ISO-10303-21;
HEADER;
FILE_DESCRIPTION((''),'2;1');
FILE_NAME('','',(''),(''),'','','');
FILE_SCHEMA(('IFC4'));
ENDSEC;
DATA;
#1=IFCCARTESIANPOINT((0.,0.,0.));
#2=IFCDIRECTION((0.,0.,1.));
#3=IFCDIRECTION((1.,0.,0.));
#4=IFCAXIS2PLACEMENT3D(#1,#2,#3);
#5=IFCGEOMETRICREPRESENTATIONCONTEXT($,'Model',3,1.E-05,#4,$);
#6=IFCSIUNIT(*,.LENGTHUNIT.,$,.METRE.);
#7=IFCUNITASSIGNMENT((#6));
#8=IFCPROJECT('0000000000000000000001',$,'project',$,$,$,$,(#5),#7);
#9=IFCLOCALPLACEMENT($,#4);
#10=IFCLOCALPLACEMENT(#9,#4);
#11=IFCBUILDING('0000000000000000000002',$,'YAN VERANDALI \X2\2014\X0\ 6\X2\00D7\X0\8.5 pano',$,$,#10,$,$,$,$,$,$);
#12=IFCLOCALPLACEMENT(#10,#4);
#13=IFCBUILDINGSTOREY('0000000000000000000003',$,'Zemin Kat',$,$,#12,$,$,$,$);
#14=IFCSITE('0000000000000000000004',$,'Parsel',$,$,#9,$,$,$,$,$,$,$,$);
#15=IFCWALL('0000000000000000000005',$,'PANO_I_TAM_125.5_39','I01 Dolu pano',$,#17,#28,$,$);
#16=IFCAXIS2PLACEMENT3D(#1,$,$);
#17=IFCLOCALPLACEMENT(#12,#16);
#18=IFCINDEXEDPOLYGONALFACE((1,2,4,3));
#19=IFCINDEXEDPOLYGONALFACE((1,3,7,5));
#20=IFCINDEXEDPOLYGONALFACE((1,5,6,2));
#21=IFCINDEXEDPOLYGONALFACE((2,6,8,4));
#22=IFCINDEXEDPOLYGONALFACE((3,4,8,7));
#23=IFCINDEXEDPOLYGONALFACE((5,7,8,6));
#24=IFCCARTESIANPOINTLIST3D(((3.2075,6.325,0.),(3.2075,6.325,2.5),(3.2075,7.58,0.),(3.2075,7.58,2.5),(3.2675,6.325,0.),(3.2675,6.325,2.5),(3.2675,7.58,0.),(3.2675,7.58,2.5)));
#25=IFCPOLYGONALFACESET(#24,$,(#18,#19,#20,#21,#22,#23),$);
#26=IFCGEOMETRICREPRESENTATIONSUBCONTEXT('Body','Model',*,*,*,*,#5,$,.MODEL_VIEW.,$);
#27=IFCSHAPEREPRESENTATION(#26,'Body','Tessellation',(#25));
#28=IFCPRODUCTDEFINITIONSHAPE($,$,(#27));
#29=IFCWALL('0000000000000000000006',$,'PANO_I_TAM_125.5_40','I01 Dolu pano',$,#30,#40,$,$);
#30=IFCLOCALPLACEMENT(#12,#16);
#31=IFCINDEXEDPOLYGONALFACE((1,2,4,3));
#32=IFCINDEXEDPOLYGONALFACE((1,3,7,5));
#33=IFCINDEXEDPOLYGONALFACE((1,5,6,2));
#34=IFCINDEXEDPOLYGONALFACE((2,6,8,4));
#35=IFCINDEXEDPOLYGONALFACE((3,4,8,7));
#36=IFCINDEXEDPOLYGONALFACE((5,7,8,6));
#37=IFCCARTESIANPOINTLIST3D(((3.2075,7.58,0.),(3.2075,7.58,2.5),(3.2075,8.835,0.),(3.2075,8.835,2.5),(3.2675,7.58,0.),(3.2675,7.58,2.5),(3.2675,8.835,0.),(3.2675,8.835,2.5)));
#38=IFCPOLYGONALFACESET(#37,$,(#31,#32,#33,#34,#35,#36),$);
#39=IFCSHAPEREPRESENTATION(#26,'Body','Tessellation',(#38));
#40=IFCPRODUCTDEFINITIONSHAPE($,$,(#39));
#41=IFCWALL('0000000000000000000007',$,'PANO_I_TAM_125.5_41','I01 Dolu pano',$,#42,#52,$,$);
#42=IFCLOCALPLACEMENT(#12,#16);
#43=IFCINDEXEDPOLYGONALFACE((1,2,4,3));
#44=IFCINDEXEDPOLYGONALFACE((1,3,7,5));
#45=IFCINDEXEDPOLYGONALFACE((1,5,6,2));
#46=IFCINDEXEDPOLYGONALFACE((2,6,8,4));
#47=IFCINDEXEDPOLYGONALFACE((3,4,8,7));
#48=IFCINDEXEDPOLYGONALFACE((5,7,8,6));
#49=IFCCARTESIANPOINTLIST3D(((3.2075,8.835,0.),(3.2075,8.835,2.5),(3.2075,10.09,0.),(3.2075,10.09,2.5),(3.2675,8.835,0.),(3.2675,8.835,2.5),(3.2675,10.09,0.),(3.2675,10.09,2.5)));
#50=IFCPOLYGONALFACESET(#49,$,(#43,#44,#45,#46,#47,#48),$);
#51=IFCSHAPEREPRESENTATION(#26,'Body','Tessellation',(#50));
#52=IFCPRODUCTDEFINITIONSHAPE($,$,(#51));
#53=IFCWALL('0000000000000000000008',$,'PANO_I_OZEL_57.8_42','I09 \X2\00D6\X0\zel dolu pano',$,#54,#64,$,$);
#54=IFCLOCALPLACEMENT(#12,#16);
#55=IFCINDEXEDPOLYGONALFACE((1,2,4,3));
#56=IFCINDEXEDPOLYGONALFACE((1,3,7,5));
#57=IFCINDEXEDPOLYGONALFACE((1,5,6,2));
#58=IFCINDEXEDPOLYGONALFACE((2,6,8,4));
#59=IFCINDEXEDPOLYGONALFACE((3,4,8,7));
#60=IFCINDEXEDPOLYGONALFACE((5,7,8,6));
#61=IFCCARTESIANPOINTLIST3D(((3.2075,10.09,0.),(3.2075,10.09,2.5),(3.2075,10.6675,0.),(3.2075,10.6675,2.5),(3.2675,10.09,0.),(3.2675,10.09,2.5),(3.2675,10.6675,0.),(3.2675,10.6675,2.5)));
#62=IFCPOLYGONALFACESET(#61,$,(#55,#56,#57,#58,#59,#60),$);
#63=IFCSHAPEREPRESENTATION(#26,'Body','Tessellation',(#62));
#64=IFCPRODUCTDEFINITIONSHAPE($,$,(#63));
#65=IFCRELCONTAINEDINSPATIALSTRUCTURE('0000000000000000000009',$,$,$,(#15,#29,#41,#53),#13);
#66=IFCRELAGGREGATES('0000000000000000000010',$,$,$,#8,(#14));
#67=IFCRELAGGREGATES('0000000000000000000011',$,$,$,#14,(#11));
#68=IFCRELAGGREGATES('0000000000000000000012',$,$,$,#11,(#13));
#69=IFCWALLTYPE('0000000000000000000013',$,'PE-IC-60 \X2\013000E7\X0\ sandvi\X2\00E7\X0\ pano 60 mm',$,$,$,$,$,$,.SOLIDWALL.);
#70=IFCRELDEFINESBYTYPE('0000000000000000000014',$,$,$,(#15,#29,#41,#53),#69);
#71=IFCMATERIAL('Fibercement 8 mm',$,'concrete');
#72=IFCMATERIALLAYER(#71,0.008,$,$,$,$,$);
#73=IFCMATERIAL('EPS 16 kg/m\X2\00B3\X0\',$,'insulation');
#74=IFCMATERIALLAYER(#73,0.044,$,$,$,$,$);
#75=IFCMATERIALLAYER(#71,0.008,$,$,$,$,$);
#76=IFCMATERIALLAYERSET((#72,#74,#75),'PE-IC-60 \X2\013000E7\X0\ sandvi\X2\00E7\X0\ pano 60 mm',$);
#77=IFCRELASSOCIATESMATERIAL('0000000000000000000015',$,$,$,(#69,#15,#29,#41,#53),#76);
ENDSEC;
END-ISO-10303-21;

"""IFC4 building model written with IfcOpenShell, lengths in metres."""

from ifc_helpers import new_model, si_unit, frame, origin_with_axes, place, context, subcontext, project, spatial, line, indexed_curve, outline, extrude, material, layer, layer_set, layer_usage, type_object, element, save


model = new_model("IFC4")

# Units and contexts
model_context = context("Model", 3, precision=1e-05, world=origin_with_axes())
body_context = subcontext(model_context, "Body", "Model", "MODEL_VIEW")
ifc_project = project(units=[si_unit("LENGTHUNIT", "METRE")], contexts=[model_context])

# Site, building, storey
site_placement = place(None, origin_with_axes())
site = spatial("IfcSite", under=ifc_project, at=site_placement, Name="Parsel")
building_placement = place(site_placement, origin_with_axes())
building = spatial("IfcBuilding", under=site, at=building_placement, Name="YAN VERANDALI — 6×8.5 pano")
storey_placement = place(building_placement, origin_with_axes())
storey = spatial("IfcBuildingStorey", under=building, at=storey_placement, Name="Zemin Kat")

# Shared definitions
ifc_material_1 = material(Name="Fibercement 8 mm", Category="concrete")
ifc_material_2 = material(Name="EPS 16 kg/m³", Category="insulation")

# Shared definitions
ifc_layer_1 = layer(ifc_material_1, 0.008)
ifc_layer_2 = layer(ifc_material_2, 0.044)
ifc_layer_3 = layer(ifc_material_1, 0.008)
ifc_layer_set_1 = layer_set([ifc_layer_1, ifc_layer_2, ifc_layer_3], Name="PE-IC-60 İç sandviç pano 60 mm")
wall_type_1 = type_object("IfcWallType", Name="PE-IC-60 İç sandviç pano 60 mm", PredefinedType="SOLIDWALL", material=ifc_layer_set_1)

# Walls
ifc_layer_usage_1 = layer_usage(ifc_layer_set_1, "AXIS2", "POSITIVE", 0.0)
wall_1_placement = place(storey_placement, frame((3.2675, 6.325, 0.0), z_axis=(0.0, 0.0, 1.0), x_axis=(0.0, 1.0, 0.0)))
element("IfcWall", 1, at=wall_1_placement, inside=storey, type_object=wall_type_1, material=ifc_layer_usage_1, Name="PANO_I_TAM_125.5_39", Description="I01 Dolu pano", context=body_context, shape_type="SweptSolid", body=[
    extrude(outline(indexed_curve([(0.0, 0.0), (1.255, 0.0), (1.255, 0.06), (0.0, 0.06)], segments=[line(1, 2, 3, 4, 1)])), origin_with_axes(), (0.0, 0.0, 1.0), 2.5),
])
ifc_layer_usage_2 = layer_usage(ifc_layer_set_1, "AXIS2", "POSITIVE", 0.0)
wall_2_placement = place(storey_placement, frame((3.2675, 7.58, 0.0), z_axis=(0.0, 0.0, 1.0), x_axis=(0.0, 1.0, 0.0)))
element("IfcWall", 2, at=wall_2_placement, inside=storey, type_object=wall_type_1, material=ifc_layer_usage_2, Name="PANO_I_TAM_125.5_40", Description="I01 Dolu pano", context=body_context, shape_type="SweptSolid", body=[
    extrude(outline(indexed_curve([(0.0, 0.0), (1.255, 0.0), (1.255, 0.06), (0.0, 0.06)], segments=[line(1, 2, 3, 4, 1)])), origin_with_axes(), (0.0, 0.0, 1.0), 2.5),
])
ifc_layer_usage_3 = layer_usage(ifc_layer_set_1, "AXIS2", "POSITIVE", 0.0)
wall_3_placement = place(storey_placement, frame((3.2675, 8.835, 0.0), z_axis=(0.0, 0.0, 1.0), x_axis=(0.0, 1.0, 0.0)))
element("IfcWall", 3, at=wall_3_placement, inside=storey, type_object=wall_type_1, material=ifc_layer_usage_3, Name="PANO_I_TAM_125.5_41", Description="I01 Dolu pano", context=body_context, shape_type="SweptSolid", body=[
    extrude(outline(indexed_curve([(0.0, 0.0), (1.255, 0.0), (1.255, 0.06), (0.0, 0.06)], segments=[line(1, 2, 3, 4, 1)])), origin_with_axes(), (0.0, 0.0, 1.0), 2.5),
])
ifc_layer_usage_4 = layer_usage(ifc_layer_set_1, "AXIS2", "POSITIVE", 0.0)
wall_4_placement = place(storey_placement, frame((3.2675, 10.09, 0.0), z_axis=(0.0, 0.0, 1.0), x_axis=(0.0, 1.0, 0.0)))
element("IfcWall", 4, at=wall_4_placement, inside=storey, type_object=wall_type_1, material=ifc_layer_usage_4, Name="PANO_I_OZEL_57.8_42", Description="I09 Özel dolu pano", context=body_context, shape_type="SweptSolid", body=[
    extrude(outline(indexed_curve([(0.0, 0.0), (0.5775, 0.0), (0.5775, 0.06), (0.0, 0.06)], segments=[line(1, 2, 3, 4, 1)])), origin_with_axes(), (0.0, 0.0, 1.0), 2.5),
])

save(model, "model.ifc")
